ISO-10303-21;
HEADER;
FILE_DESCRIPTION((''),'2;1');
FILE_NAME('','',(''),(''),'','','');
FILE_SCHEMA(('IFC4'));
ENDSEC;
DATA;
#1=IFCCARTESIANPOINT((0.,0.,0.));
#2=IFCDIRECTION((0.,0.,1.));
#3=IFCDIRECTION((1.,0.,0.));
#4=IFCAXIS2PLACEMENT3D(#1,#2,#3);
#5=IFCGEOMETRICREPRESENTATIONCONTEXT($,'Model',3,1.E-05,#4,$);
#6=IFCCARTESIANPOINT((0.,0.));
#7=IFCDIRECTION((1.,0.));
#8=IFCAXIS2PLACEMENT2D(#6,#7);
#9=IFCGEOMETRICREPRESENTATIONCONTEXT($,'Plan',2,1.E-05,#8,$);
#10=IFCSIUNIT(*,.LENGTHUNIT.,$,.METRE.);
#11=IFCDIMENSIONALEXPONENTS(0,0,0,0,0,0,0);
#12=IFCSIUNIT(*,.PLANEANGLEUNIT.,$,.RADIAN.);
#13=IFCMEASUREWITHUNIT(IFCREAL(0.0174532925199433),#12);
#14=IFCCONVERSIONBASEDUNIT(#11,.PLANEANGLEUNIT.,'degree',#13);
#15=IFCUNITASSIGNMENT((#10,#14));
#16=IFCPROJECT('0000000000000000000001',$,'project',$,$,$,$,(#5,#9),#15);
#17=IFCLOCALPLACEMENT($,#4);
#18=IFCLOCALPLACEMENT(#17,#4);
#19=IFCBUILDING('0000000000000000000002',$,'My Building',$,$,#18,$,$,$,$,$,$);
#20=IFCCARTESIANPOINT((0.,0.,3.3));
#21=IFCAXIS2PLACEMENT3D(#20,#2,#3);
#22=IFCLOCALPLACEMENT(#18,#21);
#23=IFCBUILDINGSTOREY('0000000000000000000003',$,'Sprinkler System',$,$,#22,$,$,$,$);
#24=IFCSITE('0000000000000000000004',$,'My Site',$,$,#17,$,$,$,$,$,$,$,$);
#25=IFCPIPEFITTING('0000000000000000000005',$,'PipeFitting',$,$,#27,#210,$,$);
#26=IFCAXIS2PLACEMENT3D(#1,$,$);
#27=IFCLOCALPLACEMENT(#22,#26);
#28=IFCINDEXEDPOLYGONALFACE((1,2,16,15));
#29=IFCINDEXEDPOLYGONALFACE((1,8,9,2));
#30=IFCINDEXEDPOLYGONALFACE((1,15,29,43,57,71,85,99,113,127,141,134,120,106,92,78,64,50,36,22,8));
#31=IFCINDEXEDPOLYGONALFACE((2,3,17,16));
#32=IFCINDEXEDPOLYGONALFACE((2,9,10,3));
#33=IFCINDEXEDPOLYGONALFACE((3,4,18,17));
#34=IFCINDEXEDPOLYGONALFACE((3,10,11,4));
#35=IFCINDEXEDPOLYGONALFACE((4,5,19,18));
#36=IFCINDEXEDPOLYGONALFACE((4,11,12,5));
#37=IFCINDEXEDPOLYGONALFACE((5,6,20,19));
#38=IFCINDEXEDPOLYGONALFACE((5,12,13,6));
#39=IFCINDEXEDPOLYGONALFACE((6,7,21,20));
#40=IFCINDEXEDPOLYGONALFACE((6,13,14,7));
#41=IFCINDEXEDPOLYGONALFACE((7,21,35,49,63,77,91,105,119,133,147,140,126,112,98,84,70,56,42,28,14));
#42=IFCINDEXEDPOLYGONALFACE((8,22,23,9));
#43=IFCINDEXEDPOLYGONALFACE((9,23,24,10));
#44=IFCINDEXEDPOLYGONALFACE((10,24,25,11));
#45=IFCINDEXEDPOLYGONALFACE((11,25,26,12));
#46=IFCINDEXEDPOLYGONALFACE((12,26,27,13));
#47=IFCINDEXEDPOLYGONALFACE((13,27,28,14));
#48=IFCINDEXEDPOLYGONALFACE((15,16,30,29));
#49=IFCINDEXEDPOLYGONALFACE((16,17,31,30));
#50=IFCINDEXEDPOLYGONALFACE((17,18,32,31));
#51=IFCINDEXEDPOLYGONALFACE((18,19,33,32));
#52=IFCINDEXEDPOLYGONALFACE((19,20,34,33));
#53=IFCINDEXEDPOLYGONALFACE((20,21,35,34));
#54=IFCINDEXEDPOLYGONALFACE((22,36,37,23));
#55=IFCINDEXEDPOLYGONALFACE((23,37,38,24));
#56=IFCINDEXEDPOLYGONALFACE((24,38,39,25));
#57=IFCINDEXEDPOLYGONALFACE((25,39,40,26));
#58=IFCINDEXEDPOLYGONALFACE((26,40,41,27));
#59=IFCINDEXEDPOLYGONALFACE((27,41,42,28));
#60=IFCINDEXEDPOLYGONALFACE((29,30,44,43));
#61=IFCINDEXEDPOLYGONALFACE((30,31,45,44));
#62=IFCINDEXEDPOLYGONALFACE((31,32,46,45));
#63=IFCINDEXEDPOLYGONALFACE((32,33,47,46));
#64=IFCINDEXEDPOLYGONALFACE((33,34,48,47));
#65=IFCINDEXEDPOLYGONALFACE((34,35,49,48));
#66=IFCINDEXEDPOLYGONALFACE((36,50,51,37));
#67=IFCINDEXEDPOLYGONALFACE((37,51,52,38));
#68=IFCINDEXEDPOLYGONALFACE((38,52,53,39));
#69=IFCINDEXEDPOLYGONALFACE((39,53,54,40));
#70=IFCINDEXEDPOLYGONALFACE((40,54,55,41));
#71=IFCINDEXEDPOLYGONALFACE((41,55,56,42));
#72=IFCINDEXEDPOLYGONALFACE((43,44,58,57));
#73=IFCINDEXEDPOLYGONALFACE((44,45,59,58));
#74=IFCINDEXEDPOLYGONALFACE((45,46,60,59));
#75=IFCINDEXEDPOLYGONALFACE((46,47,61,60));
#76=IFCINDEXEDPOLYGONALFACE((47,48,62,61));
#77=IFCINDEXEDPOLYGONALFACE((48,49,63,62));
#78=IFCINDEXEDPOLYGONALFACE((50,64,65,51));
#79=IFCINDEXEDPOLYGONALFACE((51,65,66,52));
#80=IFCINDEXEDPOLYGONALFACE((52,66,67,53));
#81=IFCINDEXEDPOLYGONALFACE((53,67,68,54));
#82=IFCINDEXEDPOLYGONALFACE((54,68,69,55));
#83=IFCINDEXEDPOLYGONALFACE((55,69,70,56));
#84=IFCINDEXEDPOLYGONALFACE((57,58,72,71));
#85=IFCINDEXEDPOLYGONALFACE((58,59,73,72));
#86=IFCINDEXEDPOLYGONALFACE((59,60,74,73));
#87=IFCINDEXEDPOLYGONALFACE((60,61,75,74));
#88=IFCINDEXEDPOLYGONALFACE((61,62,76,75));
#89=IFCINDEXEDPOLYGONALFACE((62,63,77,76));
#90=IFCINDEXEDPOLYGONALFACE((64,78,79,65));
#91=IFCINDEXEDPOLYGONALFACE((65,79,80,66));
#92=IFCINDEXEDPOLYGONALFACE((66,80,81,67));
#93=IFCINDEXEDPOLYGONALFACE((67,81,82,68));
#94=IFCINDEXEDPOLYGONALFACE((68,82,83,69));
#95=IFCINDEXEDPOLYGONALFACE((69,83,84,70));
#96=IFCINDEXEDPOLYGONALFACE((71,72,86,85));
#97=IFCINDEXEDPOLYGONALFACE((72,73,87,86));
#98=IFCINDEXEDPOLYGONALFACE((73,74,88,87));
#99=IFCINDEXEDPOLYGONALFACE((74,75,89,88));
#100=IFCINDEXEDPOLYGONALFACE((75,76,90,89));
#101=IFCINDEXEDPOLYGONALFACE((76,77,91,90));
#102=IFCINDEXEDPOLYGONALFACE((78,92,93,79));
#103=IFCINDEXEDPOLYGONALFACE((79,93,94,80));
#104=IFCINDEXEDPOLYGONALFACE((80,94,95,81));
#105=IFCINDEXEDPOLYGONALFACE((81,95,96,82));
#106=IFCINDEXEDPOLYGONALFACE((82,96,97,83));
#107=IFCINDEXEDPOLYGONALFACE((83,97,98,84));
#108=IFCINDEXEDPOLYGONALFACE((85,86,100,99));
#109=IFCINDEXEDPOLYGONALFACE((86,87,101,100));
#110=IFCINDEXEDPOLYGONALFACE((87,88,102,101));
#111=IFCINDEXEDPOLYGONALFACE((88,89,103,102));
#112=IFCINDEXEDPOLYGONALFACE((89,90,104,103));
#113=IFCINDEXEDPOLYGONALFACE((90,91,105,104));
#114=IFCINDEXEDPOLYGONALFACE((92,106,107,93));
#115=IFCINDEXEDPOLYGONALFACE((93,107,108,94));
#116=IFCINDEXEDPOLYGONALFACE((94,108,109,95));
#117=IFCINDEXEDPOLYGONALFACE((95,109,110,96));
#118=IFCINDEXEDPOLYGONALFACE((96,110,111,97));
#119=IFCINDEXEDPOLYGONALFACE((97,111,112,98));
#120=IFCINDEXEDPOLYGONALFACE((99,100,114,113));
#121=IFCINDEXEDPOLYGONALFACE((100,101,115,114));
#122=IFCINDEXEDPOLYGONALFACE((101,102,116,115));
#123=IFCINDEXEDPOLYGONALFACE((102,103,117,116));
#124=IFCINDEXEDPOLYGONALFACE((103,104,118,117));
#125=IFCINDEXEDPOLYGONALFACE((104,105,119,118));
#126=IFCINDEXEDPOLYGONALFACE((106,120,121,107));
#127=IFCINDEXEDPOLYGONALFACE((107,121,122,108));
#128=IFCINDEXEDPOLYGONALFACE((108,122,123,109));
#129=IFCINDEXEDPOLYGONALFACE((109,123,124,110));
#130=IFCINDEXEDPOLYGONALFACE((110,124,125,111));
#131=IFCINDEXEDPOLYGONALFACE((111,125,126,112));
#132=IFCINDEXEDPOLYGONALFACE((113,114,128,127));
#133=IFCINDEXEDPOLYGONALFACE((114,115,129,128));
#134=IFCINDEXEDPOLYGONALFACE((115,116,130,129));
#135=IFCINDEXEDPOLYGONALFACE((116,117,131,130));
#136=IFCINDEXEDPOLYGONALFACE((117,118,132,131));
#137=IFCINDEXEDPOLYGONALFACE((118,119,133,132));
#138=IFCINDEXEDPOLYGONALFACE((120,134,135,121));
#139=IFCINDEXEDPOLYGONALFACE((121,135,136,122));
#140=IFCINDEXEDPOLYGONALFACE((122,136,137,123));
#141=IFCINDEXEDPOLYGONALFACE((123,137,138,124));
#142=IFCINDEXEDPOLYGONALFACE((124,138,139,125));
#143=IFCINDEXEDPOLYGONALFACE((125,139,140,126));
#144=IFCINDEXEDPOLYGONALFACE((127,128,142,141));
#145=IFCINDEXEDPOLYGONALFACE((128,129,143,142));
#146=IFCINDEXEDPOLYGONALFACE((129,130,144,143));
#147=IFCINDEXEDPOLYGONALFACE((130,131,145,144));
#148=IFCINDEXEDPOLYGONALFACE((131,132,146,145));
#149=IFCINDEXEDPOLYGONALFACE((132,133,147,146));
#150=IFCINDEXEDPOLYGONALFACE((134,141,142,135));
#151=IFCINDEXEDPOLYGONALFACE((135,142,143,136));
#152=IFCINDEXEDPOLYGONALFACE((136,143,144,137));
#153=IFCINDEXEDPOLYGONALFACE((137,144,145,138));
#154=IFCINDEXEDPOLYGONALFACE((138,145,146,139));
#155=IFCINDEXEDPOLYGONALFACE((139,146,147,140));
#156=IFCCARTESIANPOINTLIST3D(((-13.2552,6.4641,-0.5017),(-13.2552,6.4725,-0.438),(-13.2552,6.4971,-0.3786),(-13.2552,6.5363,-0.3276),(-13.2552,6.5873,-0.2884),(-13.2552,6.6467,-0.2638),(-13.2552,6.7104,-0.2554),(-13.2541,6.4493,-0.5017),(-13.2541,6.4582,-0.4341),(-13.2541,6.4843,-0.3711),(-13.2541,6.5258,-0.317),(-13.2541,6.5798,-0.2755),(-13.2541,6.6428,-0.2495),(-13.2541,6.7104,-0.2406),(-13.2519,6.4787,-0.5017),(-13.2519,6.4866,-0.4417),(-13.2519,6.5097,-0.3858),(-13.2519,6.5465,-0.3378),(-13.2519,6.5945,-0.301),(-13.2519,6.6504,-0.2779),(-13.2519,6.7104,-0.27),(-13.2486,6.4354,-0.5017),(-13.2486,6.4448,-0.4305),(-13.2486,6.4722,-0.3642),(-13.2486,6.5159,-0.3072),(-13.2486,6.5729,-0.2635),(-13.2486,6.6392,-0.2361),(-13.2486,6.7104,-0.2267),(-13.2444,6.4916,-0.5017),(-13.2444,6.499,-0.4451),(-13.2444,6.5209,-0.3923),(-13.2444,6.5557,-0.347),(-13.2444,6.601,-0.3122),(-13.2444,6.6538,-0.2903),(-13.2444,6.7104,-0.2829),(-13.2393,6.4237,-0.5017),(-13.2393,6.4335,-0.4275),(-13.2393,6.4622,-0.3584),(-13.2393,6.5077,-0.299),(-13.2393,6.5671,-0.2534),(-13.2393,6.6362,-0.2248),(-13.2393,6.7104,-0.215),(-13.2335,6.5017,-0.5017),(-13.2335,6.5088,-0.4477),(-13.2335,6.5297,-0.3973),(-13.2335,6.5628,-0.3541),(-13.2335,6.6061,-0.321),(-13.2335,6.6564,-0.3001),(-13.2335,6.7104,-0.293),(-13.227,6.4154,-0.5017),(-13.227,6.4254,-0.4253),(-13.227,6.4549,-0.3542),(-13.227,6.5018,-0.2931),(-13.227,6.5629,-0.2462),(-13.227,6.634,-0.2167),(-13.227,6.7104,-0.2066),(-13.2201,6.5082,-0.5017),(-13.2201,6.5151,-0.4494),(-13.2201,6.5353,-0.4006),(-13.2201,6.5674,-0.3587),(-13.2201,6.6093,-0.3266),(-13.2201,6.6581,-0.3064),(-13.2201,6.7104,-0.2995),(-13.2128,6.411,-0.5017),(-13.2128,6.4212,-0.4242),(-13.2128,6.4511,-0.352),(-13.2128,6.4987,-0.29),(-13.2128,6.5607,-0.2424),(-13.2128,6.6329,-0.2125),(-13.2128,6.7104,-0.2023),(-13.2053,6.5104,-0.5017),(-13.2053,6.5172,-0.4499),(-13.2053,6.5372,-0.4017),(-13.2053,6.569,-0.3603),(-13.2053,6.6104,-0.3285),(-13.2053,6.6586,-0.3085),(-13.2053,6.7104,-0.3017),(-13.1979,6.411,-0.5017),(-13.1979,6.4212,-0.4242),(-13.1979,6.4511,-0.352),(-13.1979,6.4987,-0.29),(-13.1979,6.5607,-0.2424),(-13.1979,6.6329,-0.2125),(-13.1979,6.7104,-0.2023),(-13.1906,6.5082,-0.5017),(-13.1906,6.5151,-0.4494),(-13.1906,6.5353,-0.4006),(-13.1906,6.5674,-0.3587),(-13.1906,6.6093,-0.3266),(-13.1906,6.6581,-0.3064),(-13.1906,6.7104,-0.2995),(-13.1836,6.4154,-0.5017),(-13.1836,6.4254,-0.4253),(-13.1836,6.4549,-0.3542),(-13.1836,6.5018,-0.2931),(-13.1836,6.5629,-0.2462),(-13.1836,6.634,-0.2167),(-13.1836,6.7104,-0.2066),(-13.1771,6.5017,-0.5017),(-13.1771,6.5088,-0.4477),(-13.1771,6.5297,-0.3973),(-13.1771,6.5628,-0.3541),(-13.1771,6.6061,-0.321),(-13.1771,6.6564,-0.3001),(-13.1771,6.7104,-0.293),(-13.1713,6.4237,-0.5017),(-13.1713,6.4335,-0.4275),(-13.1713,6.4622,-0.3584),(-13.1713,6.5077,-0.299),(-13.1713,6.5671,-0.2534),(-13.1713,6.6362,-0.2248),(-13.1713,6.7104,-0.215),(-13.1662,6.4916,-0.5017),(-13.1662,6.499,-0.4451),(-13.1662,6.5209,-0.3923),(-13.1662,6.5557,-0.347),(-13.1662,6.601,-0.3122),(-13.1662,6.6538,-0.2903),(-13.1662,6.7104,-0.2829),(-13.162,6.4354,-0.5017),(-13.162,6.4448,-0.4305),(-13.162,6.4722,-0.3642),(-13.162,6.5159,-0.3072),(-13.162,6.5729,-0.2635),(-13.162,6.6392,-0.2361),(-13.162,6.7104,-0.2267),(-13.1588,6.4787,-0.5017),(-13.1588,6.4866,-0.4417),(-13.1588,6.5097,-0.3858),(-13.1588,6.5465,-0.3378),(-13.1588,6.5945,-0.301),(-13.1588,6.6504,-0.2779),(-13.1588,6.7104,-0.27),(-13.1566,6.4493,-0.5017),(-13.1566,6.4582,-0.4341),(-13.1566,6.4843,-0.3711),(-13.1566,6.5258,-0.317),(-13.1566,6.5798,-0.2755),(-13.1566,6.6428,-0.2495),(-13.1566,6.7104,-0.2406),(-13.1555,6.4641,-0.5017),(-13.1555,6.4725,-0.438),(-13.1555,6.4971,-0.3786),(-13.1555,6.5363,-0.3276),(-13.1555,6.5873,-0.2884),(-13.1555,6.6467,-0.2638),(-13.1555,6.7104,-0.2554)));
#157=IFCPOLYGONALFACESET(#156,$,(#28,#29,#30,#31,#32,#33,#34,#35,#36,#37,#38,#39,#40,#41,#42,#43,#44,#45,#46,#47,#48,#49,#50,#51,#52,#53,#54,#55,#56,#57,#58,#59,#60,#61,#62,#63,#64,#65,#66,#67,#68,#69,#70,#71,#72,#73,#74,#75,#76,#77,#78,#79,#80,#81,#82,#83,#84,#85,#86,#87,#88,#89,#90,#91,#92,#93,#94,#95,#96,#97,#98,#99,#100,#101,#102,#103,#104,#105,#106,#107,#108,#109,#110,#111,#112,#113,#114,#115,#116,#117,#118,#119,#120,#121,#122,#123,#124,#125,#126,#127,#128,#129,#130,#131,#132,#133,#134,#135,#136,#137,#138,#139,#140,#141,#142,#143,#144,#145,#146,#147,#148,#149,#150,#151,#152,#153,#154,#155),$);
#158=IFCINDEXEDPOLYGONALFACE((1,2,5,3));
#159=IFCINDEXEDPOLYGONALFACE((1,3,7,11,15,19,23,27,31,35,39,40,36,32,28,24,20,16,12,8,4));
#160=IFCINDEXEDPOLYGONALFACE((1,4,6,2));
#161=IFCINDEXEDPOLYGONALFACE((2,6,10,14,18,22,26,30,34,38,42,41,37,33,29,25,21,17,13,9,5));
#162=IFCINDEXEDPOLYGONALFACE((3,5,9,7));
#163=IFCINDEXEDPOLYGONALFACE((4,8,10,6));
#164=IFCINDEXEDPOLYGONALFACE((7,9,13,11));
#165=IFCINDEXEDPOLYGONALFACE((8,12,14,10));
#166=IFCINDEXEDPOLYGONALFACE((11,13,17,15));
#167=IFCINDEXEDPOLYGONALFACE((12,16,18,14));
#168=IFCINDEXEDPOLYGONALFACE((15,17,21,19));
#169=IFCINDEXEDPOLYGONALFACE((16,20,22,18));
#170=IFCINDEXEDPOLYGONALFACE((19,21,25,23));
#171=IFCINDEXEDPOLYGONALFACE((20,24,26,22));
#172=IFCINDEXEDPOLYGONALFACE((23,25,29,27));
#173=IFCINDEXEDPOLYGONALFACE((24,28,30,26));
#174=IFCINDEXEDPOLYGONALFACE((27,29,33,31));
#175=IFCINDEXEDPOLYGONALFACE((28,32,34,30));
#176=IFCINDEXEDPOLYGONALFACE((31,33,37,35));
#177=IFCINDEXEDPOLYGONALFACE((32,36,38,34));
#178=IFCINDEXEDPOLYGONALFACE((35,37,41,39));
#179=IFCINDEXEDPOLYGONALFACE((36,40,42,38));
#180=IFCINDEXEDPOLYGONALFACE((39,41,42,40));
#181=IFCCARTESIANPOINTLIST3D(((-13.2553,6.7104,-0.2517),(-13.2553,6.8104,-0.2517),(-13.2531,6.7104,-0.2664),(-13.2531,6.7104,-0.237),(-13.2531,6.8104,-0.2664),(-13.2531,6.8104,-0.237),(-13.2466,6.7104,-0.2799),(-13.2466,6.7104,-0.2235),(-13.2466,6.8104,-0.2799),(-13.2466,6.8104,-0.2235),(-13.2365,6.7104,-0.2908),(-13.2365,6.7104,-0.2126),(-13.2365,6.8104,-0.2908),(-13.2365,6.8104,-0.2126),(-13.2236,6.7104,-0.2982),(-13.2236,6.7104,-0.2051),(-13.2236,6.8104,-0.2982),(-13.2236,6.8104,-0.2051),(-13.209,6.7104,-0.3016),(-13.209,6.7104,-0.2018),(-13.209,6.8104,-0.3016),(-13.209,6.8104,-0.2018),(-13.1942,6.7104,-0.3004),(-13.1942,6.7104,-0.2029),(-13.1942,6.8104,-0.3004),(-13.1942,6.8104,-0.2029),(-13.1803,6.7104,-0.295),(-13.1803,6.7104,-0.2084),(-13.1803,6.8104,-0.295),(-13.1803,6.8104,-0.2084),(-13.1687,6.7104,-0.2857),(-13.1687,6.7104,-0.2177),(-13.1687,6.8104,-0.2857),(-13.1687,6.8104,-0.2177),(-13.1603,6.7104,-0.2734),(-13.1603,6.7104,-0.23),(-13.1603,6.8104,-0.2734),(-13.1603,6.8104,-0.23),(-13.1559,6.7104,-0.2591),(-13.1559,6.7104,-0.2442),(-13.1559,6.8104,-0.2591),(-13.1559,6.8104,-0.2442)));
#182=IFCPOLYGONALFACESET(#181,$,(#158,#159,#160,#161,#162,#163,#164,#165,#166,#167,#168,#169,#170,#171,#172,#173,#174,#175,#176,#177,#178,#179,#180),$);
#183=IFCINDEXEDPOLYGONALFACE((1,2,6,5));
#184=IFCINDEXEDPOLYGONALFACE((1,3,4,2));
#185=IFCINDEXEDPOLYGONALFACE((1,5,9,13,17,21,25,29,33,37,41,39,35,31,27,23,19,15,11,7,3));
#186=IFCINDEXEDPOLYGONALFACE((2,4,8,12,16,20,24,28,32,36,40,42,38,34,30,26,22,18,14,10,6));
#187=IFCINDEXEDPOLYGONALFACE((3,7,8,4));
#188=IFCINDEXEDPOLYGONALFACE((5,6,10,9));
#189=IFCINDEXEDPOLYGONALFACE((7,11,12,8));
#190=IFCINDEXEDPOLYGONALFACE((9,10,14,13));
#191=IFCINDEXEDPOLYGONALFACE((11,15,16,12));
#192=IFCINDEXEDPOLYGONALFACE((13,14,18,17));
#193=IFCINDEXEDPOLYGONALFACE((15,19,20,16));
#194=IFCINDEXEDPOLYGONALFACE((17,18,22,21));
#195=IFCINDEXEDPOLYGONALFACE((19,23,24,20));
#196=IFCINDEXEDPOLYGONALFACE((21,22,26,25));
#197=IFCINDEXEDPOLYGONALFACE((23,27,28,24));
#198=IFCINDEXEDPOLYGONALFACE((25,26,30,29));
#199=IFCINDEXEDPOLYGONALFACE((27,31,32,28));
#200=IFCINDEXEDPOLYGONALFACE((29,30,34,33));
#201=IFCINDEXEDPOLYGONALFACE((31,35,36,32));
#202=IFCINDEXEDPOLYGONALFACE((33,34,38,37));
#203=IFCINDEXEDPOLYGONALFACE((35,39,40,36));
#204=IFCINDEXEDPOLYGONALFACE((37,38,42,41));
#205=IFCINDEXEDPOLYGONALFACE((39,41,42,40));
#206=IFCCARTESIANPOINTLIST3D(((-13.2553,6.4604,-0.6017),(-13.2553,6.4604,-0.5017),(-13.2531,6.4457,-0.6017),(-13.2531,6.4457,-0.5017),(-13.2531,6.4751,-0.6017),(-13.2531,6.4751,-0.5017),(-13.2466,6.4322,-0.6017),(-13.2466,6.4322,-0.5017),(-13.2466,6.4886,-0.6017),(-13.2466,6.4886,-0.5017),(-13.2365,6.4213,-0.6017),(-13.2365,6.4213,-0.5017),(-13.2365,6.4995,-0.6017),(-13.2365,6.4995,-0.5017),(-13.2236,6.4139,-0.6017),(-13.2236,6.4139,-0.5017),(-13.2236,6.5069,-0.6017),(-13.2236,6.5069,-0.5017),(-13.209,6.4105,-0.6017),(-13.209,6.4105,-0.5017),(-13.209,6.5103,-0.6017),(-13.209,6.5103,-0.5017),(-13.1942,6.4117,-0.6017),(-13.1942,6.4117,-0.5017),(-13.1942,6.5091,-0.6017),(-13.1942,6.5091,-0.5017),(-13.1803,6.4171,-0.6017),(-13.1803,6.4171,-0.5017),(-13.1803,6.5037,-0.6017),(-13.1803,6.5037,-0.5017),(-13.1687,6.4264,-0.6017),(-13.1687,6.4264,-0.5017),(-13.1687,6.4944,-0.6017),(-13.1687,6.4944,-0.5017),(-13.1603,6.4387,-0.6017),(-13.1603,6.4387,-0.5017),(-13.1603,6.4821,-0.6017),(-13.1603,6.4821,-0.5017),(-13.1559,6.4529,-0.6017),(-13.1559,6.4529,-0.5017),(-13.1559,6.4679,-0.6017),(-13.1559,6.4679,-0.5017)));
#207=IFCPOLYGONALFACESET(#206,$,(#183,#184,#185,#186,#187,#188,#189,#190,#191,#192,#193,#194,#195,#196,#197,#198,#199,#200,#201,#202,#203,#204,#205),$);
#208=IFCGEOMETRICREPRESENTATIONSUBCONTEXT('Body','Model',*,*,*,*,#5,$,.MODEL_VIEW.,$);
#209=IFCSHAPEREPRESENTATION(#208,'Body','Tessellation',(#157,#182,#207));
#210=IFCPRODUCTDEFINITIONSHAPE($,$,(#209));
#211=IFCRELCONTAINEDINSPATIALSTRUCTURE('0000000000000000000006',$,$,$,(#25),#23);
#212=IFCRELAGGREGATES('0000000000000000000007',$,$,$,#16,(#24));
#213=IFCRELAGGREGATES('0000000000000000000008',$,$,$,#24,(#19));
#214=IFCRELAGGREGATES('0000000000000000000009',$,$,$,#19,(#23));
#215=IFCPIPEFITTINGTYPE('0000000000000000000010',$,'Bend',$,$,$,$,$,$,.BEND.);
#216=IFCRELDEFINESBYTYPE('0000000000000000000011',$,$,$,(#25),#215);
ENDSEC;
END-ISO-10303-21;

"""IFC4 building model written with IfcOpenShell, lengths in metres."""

from ifc_helpers import new_model, entity, si_unit, converted_unit, frame, origin_with_axes, origin_2d_with_axis, place, context, subcontext, project, spatial, circle, extrude, source, transform, mapped, type_object, type_shapes, element, save


model = new_model("IFC4")

# Units and contexts
model_context = context("Model", 3, precision=1e-05, world=origin_with_axes())
plan_context = context("Plan", 2, precision=1e-05, world=origin_2d_with_axis())
body_context = subcontext(model_context, "Body", "Model", "MODEL_VIEW")
ifc_project = project(units=[si_unit("LENGTHUNIT", "METRE"), converted_unit("PLANEANGLEUNIT", "degree", entity("IfcReal", 0.0174532925199433), si_unit("PLANEANGLEUNIT", "RADIAN"), dimensions=[0, 0, 0, 0, 0, 0, 0])], contexts=[model_context, plan_context])

# Site, building, storey
site_placement = place(None, origin_with_axes())
site = spatial("IfcSite", under=ifc_project, at=site_placement, Name="My Site")
building_placement = place(site_placement, origin_with_axes())
building = spatial("IfcBuilding", under=site, at=building_placement, Name="My Building")
storey_placement = place(building_placement, frame((0.0, 0.0, 3.3), z_axis=(0.0, 0.0, 1.0), x_axis=(1.0, 0.0, 0.0)))
storey = spatial("IfcBuildingStorey", under=building, at=storey_placement, Name="Sprinkler System")

# Pipe fitting
pipe_fitting_type_1 = type_object("IfcPipeFittingType", Name="Bend", PredefinedType="BEND")
shared_shape_1 = source(origin_with_axes(), body_context, "Body", "SolidModel", [
    entity("IfcSweptDiskSolid", entity("IfcIndexedPolyCurve", entity("IfcCartesianPointList3D", [[0.0, 0.0, -0.1], [0.0, -0.0732, -0.2768], [0.0, -0.25, -0.35]]), [entity("IfcArcIndex", [1, 2, 3])]), 0.05),
    extrude(circle(Radius=0.05), origin_with_axes(), (0.0, 0.0, -1.0), 0.1),
    extrude(circle(Radius=0.05), frame((0.0, -0.25, -0.35), z_axis=(0.0, -1.0, 0.000012), x_axis=(1.0, 0.0, 0.0)), (0.0, 0.0, 1.0), 0.1),
])
type_shapes(pipe_fitting_type_1, [shared_shape_1])
for number, where, z_axis, x_axis, name in (
    (1, (-13.2053, 6.8104, -0.2517), (0.0, 1.0, -0.000012), (-1.0, 0.0, 0.0), "PipeFitting"),
):
    element("IfcPipeFitting", number, at=place(storey_placement, frame(where, z_axis=z_axis, x_axis=x_axis)), inside=storey, type_object=pipe_fitting_type_1, Name=name, context=body_context, shape_type="MappedRepresentation", body=[
        mapped(shared_shape_1, transform((0.0, 0.0, 0.0), x_axis=(1.0, 0.0, 0.0), y_axis=(0.0, 1.0, 0.0), z_axis=(0.0, 0.0, 1.0), scale=1.0)),
    ])

save(model, "model.ifc")
